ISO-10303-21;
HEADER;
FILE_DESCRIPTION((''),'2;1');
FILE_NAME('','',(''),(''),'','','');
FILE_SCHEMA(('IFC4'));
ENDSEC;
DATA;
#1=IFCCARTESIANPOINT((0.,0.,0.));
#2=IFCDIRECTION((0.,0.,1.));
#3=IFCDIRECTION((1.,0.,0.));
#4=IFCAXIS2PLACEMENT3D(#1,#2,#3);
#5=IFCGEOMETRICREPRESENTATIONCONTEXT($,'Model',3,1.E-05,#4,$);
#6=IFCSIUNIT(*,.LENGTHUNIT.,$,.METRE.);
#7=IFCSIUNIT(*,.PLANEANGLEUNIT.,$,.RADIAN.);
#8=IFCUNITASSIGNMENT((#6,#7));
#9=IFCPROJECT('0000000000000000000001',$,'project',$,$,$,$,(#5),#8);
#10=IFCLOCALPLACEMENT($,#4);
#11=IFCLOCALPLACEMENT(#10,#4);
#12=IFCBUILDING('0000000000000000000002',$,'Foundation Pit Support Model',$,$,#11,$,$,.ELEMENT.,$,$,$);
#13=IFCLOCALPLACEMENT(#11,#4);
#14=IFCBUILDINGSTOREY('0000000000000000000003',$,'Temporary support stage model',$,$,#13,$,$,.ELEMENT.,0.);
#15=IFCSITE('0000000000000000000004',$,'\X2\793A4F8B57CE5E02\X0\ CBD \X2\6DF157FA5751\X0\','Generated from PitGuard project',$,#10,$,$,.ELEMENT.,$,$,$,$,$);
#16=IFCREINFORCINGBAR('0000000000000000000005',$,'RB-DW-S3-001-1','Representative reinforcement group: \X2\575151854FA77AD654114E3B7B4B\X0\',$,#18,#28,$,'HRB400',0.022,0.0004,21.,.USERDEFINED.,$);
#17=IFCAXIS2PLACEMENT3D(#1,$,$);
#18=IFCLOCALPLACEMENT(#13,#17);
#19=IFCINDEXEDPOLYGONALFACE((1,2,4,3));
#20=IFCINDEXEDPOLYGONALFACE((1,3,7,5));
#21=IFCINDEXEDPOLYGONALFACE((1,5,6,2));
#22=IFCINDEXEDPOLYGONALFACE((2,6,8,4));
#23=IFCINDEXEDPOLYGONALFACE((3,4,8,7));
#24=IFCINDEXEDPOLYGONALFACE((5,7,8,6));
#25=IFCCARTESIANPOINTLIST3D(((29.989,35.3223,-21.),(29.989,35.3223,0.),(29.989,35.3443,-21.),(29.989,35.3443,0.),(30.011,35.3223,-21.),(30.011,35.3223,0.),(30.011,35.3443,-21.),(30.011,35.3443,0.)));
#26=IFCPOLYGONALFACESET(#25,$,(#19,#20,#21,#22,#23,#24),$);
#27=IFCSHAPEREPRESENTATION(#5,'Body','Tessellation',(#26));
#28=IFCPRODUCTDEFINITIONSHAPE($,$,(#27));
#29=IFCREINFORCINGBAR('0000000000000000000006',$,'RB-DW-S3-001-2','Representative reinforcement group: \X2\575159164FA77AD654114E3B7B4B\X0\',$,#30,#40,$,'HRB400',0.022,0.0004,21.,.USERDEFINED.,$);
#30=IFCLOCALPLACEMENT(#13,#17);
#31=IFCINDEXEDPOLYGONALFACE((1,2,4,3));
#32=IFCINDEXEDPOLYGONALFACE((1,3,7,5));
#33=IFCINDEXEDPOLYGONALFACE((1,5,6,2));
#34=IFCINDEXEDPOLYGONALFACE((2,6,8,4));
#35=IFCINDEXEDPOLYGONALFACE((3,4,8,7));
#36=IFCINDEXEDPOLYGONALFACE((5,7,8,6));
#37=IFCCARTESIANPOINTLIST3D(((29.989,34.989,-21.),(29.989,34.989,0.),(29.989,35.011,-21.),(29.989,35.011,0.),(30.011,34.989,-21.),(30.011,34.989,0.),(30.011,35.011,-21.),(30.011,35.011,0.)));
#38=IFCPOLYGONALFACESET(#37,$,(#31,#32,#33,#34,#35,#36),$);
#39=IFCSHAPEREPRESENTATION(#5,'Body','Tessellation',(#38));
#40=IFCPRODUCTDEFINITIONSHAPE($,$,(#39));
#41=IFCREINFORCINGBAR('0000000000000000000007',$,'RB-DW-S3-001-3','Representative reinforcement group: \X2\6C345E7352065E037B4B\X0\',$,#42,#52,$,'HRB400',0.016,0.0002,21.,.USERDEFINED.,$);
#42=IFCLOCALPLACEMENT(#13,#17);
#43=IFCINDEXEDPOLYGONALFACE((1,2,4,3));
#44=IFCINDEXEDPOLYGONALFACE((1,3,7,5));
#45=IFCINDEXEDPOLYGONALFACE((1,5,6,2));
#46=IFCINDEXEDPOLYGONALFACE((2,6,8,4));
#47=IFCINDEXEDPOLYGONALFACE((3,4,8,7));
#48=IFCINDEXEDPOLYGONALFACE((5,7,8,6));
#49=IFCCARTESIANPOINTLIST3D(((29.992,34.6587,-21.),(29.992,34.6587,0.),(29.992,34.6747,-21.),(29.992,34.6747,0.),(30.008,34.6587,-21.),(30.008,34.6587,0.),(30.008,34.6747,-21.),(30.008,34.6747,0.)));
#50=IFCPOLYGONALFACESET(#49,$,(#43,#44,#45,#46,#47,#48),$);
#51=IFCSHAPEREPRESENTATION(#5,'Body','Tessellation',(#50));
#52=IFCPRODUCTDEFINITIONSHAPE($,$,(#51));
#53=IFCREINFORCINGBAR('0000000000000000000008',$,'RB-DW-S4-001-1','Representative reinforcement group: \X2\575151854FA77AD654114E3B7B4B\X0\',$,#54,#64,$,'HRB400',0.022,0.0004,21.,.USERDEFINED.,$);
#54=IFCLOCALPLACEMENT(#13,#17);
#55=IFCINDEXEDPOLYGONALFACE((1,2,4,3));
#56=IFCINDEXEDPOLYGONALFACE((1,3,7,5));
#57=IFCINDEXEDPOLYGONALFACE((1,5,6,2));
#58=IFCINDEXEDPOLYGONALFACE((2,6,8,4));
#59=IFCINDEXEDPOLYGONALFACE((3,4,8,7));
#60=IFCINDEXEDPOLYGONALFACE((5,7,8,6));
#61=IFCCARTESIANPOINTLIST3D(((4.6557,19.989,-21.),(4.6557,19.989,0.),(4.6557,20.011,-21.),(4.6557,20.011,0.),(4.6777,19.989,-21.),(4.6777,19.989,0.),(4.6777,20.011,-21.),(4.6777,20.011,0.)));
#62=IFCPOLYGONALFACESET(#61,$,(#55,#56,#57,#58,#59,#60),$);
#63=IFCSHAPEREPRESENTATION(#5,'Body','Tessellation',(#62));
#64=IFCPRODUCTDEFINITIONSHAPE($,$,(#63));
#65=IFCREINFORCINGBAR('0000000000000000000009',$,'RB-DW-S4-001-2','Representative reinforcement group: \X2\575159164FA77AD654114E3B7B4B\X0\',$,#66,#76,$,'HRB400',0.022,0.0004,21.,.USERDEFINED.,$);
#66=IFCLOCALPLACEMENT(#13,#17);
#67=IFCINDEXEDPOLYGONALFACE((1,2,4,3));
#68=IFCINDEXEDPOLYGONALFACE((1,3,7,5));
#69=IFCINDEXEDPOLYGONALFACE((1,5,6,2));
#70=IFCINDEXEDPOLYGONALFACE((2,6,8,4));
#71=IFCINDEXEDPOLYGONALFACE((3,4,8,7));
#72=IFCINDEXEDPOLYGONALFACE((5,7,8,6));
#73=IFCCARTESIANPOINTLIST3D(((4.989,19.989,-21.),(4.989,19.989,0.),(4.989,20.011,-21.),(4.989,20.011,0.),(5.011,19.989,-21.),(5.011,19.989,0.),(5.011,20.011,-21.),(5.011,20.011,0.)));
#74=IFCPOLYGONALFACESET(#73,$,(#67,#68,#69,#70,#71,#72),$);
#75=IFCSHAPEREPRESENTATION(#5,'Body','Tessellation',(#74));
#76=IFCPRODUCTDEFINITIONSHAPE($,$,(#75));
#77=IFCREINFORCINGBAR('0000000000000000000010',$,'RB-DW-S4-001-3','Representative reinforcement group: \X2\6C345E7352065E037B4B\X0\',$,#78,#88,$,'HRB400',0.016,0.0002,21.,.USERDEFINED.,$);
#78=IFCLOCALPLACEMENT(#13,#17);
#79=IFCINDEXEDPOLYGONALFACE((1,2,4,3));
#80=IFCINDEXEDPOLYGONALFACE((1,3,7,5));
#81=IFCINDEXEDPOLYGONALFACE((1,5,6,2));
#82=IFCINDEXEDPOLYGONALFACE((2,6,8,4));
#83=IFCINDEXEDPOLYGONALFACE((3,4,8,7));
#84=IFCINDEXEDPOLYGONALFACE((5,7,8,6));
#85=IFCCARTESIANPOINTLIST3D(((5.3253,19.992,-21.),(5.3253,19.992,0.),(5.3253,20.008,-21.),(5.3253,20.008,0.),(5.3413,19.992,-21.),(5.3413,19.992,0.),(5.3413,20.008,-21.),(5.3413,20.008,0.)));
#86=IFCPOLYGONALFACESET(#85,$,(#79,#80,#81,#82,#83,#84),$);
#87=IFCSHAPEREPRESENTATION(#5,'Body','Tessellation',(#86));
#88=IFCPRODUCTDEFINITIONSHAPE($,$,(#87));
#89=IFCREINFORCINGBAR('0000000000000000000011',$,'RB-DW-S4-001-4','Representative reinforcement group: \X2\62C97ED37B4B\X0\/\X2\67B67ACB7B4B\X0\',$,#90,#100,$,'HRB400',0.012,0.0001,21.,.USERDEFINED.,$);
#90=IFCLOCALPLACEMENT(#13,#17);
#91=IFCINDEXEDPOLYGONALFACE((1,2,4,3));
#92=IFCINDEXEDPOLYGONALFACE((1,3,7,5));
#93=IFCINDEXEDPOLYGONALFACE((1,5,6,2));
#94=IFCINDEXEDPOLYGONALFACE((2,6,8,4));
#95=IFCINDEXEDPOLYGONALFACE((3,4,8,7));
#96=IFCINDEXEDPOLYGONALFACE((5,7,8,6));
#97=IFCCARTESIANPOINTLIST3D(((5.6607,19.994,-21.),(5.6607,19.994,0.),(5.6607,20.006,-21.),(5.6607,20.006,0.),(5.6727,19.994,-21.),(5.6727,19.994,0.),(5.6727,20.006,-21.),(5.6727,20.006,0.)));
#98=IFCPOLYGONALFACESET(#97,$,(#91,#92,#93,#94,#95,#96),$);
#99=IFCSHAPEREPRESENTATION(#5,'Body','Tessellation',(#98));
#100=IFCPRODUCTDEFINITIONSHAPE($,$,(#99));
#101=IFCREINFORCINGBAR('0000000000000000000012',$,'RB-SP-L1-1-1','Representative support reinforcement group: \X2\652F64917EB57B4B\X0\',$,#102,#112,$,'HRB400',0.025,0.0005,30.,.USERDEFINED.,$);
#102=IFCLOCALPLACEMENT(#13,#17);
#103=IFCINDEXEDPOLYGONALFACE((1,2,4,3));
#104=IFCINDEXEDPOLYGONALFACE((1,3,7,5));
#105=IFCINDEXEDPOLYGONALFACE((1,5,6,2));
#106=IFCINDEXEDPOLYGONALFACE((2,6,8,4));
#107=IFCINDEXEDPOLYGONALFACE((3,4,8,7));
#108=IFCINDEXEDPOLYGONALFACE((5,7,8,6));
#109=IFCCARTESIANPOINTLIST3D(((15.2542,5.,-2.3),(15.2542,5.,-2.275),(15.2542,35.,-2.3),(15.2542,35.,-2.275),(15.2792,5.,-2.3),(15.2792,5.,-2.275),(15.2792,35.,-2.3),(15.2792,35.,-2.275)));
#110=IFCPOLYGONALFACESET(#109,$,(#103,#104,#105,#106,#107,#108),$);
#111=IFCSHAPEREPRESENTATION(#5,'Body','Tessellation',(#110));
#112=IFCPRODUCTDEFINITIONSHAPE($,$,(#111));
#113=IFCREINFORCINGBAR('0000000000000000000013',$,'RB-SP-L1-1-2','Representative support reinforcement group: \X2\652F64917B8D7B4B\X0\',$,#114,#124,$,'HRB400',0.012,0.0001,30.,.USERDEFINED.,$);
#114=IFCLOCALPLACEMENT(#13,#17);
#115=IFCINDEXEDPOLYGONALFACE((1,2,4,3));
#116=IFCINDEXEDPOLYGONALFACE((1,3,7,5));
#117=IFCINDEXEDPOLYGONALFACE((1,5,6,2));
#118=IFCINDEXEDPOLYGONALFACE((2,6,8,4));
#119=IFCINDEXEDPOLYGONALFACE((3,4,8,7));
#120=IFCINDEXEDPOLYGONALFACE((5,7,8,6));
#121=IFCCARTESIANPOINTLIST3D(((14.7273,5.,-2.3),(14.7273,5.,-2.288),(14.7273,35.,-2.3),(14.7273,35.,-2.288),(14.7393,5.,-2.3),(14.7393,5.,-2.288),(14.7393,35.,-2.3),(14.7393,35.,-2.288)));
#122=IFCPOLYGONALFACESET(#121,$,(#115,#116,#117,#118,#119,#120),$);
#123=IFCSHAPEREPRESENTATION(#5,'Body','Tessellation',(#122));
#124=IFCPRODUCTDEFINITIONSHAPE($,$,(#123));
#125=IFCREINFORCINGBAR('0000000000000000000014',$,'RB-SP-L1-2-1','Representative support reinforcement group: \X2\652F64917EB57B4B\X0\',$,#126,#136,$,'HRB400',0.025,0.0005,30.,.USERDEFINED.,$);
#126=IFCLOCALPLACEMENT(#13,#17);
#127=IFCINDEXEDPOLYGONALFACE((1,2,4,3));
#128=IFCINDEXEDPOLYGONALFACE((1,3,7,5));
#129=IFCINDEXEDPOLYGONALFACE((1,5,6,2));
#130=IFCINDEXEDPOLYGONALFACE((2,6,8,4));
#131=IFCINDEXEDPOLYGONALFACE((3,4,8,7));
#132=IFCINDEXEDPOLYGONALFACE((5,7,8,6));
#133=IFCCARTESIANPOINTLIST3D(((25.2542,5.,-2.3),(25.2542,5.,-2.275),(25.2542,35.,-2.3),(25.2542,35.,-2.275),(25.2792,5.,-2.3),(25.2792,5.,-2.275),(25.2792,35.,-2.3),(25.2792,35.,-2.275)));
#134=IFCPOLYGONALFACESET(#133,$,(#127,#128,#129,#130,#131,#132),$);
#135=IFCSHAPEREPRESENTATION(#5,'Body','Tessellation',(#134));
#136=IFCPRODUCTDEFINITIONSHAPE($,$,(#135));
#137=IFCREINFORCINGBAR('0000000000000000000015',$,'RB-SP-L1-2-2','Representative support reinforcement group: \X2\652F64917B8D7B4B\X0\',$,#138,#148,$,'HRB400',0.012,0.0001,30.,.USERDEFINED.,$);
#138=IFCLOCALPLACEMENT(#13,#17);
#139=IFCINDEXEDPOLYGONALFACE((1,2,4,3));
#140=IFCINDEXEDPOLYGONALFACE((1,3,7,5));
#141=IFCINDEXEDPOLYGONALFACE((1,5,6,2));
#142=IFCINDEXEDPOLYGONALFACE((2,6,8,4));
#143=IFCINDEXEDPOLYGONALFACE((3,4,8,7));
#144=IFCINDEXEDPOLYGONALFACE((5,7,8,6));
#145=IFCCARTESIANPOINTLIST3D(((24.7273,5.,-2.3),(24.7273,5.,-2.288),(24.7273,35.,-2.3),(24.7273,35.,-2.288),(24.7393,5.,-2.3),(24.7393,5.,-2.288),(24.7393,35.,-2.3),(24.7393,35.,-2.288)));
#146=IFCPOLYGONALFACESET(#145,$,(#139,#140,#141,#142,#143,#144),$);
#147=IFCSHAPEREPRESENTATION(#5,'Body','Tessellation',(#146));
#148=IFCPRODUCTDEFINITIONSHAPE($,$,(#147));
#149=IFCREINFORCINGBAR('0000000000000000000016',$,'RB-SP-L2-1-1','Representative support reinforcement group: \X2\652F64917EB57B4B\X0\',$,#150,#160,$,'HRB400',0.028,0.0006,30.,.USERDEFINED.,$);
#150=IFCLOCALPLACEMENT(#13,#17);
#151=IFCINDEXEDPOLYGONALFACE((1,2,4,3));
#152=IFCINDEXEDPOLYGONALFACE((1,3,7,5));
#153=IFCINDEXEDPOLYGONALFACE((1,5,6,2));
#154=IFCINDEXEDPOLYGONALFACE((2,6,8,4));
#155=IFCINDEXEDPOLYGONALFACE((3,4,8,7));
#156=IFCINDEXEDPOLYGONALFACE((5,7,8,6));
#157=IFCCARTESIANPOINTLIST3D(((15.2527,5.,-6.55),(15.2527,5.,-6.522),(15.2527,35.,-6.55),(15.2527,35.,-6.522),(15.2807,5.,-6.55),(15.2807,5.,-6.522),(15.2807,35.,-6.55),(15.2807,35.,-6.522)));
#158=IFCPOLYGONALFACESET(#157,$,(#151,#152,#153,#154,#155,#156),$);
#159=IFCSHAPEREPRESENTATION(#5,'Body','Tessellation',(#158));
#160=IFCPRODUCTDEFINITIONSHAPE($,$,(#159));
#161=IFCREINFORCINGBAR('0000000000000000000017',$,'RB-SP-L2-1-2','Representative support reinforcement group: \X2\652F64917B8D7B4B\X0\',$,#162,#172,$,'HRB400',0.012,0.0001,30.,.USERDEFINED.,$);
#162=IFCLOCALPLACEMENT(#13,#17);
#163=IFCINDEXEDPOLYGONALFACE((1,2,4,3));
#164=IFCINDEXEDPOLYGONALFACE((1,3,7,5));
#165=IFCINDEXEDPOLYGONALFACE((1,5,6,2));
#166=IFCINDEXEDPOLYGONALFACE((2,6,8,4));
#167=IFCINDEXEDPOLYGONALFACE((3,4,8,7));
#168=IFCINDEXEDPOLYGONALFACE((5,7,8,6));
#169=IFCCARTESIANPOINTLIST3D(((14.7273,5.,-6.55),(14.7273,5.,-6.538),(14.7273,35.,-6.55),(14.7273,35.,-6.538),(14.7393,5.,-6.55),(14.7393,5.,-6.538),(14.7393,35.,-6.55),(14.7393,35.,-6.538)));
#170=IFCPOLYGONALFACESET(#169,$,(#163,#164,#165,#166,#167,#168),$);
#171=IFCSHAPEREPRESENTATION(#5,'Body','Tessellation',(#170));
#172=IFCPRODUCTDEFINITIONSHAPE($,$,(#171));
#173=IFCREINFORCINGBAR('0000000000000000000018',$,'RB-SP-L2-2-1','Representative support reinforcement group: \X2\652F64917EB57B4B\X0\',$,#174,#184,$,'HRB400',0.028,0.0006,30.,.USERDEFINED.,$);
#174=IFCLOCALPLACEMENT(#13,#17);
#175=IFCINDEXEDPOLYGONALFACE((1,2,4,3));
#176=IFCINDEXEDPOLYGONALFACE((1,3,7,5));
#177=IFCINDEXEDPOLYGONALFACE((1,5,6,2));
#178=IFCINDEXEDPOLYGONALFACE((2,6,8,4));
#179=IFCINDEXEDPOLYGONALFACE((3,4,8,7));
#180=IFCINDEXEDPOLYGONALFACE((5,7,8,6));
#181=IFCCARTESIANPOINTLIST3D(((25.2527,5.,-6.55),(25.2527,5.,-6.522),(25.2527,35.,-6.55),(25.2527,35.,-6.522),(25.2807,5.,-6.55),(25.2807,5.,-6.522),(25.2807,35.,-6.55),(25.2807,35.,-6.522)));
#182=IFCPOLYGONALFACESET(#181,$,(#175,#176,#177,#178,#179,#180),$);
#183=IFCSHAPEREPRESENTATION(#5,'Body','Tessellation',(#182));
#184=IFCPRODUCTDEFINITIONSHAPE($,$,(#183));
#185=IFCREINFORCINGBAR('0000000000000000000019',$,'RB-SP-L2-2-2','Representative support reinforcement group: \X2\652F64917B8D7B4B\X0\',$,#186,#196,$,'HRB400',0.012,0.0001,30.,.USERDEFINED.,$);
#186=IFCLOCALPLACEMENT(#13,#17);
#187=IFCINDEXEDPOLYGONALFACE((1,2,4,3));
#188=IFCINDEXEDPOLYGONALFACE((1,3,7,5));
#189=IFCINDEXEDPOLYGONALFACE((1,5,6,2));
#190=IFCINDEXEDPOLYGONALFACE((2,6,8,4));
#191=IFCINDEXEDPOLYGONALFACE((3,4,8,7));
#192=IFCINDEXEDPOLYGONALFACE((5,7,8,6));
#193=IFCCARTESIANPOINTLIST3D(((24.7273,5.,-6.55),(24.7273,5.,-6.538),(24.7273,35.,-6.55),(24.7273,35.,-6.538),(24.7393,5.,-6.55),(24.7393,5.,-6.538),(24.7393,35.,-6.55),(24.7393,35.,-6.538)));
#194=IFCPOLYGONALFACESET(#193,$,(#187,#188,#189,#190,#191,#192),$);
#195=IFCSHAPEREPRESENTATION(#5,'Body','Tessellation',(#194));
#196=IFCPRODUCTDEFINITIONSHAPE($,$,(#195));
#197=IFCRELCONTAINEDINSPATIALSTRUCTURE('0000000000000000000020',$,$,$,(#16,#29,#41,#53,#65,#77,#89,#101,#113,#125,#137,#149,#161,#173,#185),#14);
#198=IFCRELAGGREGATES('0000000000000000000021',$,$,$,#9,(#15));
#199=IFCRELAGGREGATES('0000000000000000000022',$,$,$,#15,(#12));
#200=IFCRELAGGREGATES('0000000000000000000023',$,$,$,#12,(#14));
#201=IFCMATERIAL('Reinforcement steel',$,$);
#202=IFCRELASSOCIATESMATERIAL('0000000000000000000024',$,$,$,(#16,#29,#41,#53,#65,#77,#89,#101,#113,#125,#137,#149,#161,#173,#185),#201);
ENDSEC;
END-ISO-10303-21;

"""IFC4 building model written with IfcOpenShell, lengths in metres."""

from ifc_helpers import new_model, si_unit, frame, origin_with_axes, origin_2d, place, context, project, spatial, rectangle, extrude, material, element, save


model = new_model("IFC4")

# Units and contexts
model_context = context("Model", 3, precision=1e-05, world=origin_with_axes())
ifc_project = project(units=[si_unit("LENGTHUNIT", "METRE"), si_unit("PLANEANGLEUNIT", "RADIAN")], contexts=[model_context])

# Site, building, storey
site_placement = place(None, origin_with_axes())
site = spatial("IfcSite", under=ifc_project, at=site_placement, Name="示例城市 CBD 深基坑", Description="Generated from PitGuard project", CompositionType="ELEMENT")
building_placement = place(site_placement, origin_with_axes())
building = spatial("IfcBuilding", under=site, at=building_placement, Name="Foundation Pit Support Model", CompositionType="ELEMENT")
storey_placement = place(building_placement, origin_with_axes())
storey = spatial("IfcBuildingStorey", under=building, at=storey_placement, Name="Temporary support stage model", CompositionType="ELEMENT", Elevation=0.0)

# Reinforcing bars
ifc_material_1 = material(Name="Reinforcement steel")
for number, where, z_axis, x_axis, name, description in (
    (1, (30.0, 35.3333, -21.0), (0.0, 0.0, 1.0), (1.0, 0.0, 0.0), "RB-DW-S3-001-1", "Representative reinforcement group: 坑内侧竖向主筋"),
    (2, (30.0, 35.0, -21.0), (0.0, 0.0, 1.0), (1.0, 0.0, 0.0), "RB-DW-S3-001-2", "Representative reinforcement group: 坑外侧竖向主筋"),
):
    element("IfcReinforcingBar", number, at=place(storey_placement, frame(where, z_axis=z_axis, x_axis=x_axis)), inside=storey, material=ifc_material_1, Name=name, Description=description, SteelGrade="HRB400", BarLength=21.0, CrossSectionArea=0.0004, NominalDiameter=0.022, PredefinedType="USERDEFINED", context=model_context, shape_type="SweptSolid", body=[
        extrude(rectangle(XDim=0.022, YDim=0.022, at=origin_2d()), origin_with_axes(), (0.0, 0.0, 1.0), 21.0),
    ])
reinforcing_bar_1_placement = place(storey_placement, frame((30.0, 34.6667, -21.0), z_axis=(0.0, 0.0, 1.0), x_axis=(1.0, 0.0, 0.0)))
element("IfcReinforcingBar", 3, at=reinforcing_bar_1_placement, inside=storey, material=ifc_material_1, Name="RB-DW-S3-001-3", Description="Representative reinforcement group: 水平分布筋", SteelGrade="HRB400", BarLength=21.0, CrossSectionArea=0.0002, NominalDiameter=0.016, PredefinedType="USERDEFINED", context=model_context, shape_type="SweptSolid", body=[
    extrude(rectangle(XDim=0.016, YDim=0.016, at=origin_2d()), origin_with_axes(), (0.0, 0.0, 1.0), 21.0),
])
for number, where, z_axis, x_axis, name, description in (
    (4, (4.6667, 20.0, -21.0), (0.0, 0.0, 1.0), (1.0, 0.0, 0.0), "RB-DW-S4-001-1", "Representative reinforcement group: 坑内侧竖向主筋"),
    (5, (5.0, 20.0, -21.0), (0.0, 0.0, 1.0), (1.0, 0.0, 0.0), "RB-DW-S4-001-2", "Representative reinforcement group: 坑外侧竖向主筋"),
):
    element("IfcReinforcingBar", number, at=place(storey_placement, frame(where, z_axis=z_axis, x_axis=x_axis)), inside=storey, material=ifc_material_1, Name=name, Description=description, SteelGrade="HRB400", BarLength=21.0, CrossSectionArea=0.0004, NominalDiameter=0.022, PredefinedType="USERDEFINED", context=model_context, shape_type="SweptSolid", body=[
        extrude(rectangle(XDim=0.022, YDim=0.022, at=origin_2d()), origin_with_axes(), (0.0, 0.0, 1.0), 21.0),
    ])
reinforcing_bar_2_placement = place(storey_placement, frame((5.3333, 20.0, -21.0), z_axis=(0.0, 0.0, 1.0), x_axis=(1.0, 0.0, 0.0)))
element("IfcReinforcingBar", 6, at=reinforcing_bar_2_placement, inside=storey, material=ifc_material_1, Name="RB-DW-S4-001-3", Description="Representative reinforcement group: 水平分布筋", SteelGrade="HRB400", BarLength=21.0, CrossSectionArea=0.0002, NominalDiameter=0.016, PredefinedType="USERDEFINED", context=model_context, shape_type="SweptSolid", body=[
    extrude(rectangle(XDim=0.016, YDim=0.016, at=origin_2d()), origin_with_axes(), (0.0, 0.0, 1.0), 21.0),
])
reinforcing_bar_3_placement = place(storey_placement, frame((5.6667, 20.0, -21.0), z_axis=(0.0, 0.0, 1.0), x_axis=(1.0, 0.0, 0.0)))
element("IfcReinforcingBar", 7, at=reinforcing_bar_3_placement, inside=storey, material=ifc_material_1, Name="RB-DW-S4-001-4", Description="Representative reinforcement group: 拉结筋/架立筋", SteelGrade="HRB400", BarLength=21.0, CrossSectionArea=0.0001, NominalDiameter=0.012, PredefinedType="USERDEFINED", context=model_context, shape_type="SweptSolid", body=[
    extrude(rectangle(XDim=0.012, YDim=0.012, at=origin_2d()), origin_with_axes(), (0.0, 0.0, 1.0), 21.0),
])
reinforcing_bar_4_placement = place(storey_placement, frame((15.2667, 20.0, -2.3), z_axis=(0.0, 0.0, 1.0), x_axis=(0.0, 1.0, 0.0)))
element("IfcReinforcingBar", 8, at=reinforcing_bar_4_placement, inside=storey, material=ifc_material_1, Name="RB-SP-L1-1-1", Description="Representative support reinforcement group: 支撑纵筋", SteelGrade="HRB400", BarLength=30.0, CrossSectionArea=0.0005, NominalDiameter=0.025, PredefinedType="USERDEFINED", context=model_context, shape_type="SweptSolid", body=[
    extrude(rectangle(XDim=30.0, YDim=0.025, at=origin_2d()), origin_with_axes(), (0.0, 0.0, 1.0), 0.025),
])
reinforcing_bar_5_placement = place(storey_placement, frame((14.7333, 20.0, -2.3), z_axis=(0.0, 0.0, 1.0), x_axis=(0.0, 1.0, 0.0)))
element("IfcReinforcingBar", 9, at=reinforcing_bar_5_placement, inside=storey, material=ifc_material_1, Name="RB-SP-L1-1-2", Description="Representative support reinforcement group: 支撑箍筋", SteelGrade="HRB400", BarLength=30.0, CrossSectionArea=0.0001, NominalDiameter=0.012, PredefinedType="USERDEFINED", context=model_context, shape_type="SweptSolid", body=[
    extrude(rectangle(XDim=30.0, YDim=0.012, at=origin_2d()), origin_with_axes(), (0.0, 0.0, 1.0), 0.012),
])
reinforcing_bar_6_placement = place(storey_placement, frame((25.2667, 20.0, -2.3), z_axis=(0.0, 0.0, 1.0), x_axis=(0.0, 1.0, 0.0)))
element("IfcReinforcingBar", 10, at=reinforcing_bar_6_placement, inside=storey, material=ifc_material_1, Name="RB-SP-L1-2-1", Description="Representative support reinforcement group: 支撑纵筋", SteelGrade="HRB400", BarLength=30.0, CrossSectionArea=0.0005, NominalDiameter=0.025, PredefinedType="USERDEFINED", context=model_context, shape_type="SweptSolid", body=[
    extrude(rectangle(XDim=30.0, YDim=0.025, at=origin_2d()), origin_with_axes(), (0.0, 0.0, 1.0), 0.025),
])
reinforcing_bar_7_placement = place(storey_placement, frame((24.7333, 20.0, -2.3), z_axis=(0.0, 0.0, 1.0), x_axis=(0.0, 1.0, 0.0)))
element("IfcReinforcingBar", 11, at=reinforcing_bar_7_placement, inside=storey, material=ifc_material_1, Name="RB-SP-L1-2-2", Description="Representative support reinforcement group: 支撑箍筋", SteelGrade="HRB400", BarLength=30.0, CrossSectionArea=0.0001, NominalDiameter=0.012, PredefinedType="USERDEFINED", context=model_context, shape_type="SweptSolid", body=[
    extrude(rectangle(XDim=30.0, YDim=0.012, at=origin_2d()), origin_with_axes(), (0.0, 0.0, 1.0), 0.012),
])
reinforcing_bar_8_placement = place(storey_placement, frame((15.2667, 20.0, -6.55), z_axis=(0.0, 0.0, 1.0), x_axis=(0.0, 1.0, 0.0)))
element("IfcReinforcingBar", 12, at=reinforcing_bar_8_placement, inside=storey, material=ifc_material_1, Name="RB-SP-L2-1-1", Description="Representative support reinforcement group: 支撑纵筋", SteelGrade="HRB400", BarLength=30.0, CrossSectionArea=0.0006, NominalDiameter=0.028, PredefinedType="USERDEFINED", context=model_context, shape_type="SweptSolid", body=[
    extrude(rectangle(XDim=30.0, YDim=0.028, at=origin_2d()), origin_with_axes(), (0.0, 0.0, 1.0), 0.028),
])
reinforcing_bar_9_placement = place(storey_placement, frame((14.7333, 20.0, -6.55), z_axis=(0.0, 0.0, 1.0), x_axis=(0.0, 1.0, 0.0)))
element("IfcReinforcingBar", 13, at=reinforcing_bar_9_placement, inside=storey, material=ifc_material_1, Name="RB-SP-L2-1-2", Description="Representative support reinforcement group: 支撑箍筋", SteelGrade="HRB400", BarLength=30.0, CrossSectionArea=0.0001, NominalDiameter=0.012, PredefinedType="USERDEFINED", context=model_context, shape_type="SweptSolid", body=[
    extrude(rectangle(XDim=30.0, YDim=0.012, at=origin_2d()), origin_with_axes(), (0.0, 0.0, 1.0), 0.012),
])
reinforcing_bar_10_placement = place(storey_placement, frame((25.2667, 20.0, -6.55), z_axis=(0.0, 0.0, 1.0), x_axis=(0.0, 1.0, 0.0)))
element("IfcReinforcingBar", 14, at=reinforcing_bar_10_placement, inside=storey, material=ifc_material_1, Name="RB-SP-L2-2-1", Description="Representative support reinforcement group: 支撑纵筋", SteelGrade="HRB400", BarLength=30.0, CrossSectionArea=0.0006, NominalDiameter=0.028, PredefinedType="USERDEFINED", context=model_context, shape_type="SweptSolid", body=[
    extrude(rectangle(XDim=30.0, YDim=0.028, at=origin_2d()), origin_with_axes(), (0.0, 0.0, 1.0), 0.028),
])
reinforcing_bar_11_placement = place(storey_placement, frame((24.7333, 20.0, -6.55), z_axis=(0.0, 0.0, 1.0), x_axis=(0.0, 1.0, 0.0)))
element("IfcReinforcingBar", 15, at=reinforcing_bar_11_placement, inside=storey, material=ifc_material_1, Name="RB-SP-L2-2-2", Description="Representative support reinforcement group: 支撑箍筋", SteelGrade="HRB400", BarLength=30.0, CrossSectionArea=0.0001, NominalDiameter=0.012, PredefinedType="USERDEFINED", context=model_context, shape_type="SweptSolid", body=[
    extrude(rectangle(XDim=30.0, YDim=0.012, at=origin_2d()), origin_with_axes(), (0.0, 0.0, 1.0), 0.012),
])

save(model, "model.ifc")
